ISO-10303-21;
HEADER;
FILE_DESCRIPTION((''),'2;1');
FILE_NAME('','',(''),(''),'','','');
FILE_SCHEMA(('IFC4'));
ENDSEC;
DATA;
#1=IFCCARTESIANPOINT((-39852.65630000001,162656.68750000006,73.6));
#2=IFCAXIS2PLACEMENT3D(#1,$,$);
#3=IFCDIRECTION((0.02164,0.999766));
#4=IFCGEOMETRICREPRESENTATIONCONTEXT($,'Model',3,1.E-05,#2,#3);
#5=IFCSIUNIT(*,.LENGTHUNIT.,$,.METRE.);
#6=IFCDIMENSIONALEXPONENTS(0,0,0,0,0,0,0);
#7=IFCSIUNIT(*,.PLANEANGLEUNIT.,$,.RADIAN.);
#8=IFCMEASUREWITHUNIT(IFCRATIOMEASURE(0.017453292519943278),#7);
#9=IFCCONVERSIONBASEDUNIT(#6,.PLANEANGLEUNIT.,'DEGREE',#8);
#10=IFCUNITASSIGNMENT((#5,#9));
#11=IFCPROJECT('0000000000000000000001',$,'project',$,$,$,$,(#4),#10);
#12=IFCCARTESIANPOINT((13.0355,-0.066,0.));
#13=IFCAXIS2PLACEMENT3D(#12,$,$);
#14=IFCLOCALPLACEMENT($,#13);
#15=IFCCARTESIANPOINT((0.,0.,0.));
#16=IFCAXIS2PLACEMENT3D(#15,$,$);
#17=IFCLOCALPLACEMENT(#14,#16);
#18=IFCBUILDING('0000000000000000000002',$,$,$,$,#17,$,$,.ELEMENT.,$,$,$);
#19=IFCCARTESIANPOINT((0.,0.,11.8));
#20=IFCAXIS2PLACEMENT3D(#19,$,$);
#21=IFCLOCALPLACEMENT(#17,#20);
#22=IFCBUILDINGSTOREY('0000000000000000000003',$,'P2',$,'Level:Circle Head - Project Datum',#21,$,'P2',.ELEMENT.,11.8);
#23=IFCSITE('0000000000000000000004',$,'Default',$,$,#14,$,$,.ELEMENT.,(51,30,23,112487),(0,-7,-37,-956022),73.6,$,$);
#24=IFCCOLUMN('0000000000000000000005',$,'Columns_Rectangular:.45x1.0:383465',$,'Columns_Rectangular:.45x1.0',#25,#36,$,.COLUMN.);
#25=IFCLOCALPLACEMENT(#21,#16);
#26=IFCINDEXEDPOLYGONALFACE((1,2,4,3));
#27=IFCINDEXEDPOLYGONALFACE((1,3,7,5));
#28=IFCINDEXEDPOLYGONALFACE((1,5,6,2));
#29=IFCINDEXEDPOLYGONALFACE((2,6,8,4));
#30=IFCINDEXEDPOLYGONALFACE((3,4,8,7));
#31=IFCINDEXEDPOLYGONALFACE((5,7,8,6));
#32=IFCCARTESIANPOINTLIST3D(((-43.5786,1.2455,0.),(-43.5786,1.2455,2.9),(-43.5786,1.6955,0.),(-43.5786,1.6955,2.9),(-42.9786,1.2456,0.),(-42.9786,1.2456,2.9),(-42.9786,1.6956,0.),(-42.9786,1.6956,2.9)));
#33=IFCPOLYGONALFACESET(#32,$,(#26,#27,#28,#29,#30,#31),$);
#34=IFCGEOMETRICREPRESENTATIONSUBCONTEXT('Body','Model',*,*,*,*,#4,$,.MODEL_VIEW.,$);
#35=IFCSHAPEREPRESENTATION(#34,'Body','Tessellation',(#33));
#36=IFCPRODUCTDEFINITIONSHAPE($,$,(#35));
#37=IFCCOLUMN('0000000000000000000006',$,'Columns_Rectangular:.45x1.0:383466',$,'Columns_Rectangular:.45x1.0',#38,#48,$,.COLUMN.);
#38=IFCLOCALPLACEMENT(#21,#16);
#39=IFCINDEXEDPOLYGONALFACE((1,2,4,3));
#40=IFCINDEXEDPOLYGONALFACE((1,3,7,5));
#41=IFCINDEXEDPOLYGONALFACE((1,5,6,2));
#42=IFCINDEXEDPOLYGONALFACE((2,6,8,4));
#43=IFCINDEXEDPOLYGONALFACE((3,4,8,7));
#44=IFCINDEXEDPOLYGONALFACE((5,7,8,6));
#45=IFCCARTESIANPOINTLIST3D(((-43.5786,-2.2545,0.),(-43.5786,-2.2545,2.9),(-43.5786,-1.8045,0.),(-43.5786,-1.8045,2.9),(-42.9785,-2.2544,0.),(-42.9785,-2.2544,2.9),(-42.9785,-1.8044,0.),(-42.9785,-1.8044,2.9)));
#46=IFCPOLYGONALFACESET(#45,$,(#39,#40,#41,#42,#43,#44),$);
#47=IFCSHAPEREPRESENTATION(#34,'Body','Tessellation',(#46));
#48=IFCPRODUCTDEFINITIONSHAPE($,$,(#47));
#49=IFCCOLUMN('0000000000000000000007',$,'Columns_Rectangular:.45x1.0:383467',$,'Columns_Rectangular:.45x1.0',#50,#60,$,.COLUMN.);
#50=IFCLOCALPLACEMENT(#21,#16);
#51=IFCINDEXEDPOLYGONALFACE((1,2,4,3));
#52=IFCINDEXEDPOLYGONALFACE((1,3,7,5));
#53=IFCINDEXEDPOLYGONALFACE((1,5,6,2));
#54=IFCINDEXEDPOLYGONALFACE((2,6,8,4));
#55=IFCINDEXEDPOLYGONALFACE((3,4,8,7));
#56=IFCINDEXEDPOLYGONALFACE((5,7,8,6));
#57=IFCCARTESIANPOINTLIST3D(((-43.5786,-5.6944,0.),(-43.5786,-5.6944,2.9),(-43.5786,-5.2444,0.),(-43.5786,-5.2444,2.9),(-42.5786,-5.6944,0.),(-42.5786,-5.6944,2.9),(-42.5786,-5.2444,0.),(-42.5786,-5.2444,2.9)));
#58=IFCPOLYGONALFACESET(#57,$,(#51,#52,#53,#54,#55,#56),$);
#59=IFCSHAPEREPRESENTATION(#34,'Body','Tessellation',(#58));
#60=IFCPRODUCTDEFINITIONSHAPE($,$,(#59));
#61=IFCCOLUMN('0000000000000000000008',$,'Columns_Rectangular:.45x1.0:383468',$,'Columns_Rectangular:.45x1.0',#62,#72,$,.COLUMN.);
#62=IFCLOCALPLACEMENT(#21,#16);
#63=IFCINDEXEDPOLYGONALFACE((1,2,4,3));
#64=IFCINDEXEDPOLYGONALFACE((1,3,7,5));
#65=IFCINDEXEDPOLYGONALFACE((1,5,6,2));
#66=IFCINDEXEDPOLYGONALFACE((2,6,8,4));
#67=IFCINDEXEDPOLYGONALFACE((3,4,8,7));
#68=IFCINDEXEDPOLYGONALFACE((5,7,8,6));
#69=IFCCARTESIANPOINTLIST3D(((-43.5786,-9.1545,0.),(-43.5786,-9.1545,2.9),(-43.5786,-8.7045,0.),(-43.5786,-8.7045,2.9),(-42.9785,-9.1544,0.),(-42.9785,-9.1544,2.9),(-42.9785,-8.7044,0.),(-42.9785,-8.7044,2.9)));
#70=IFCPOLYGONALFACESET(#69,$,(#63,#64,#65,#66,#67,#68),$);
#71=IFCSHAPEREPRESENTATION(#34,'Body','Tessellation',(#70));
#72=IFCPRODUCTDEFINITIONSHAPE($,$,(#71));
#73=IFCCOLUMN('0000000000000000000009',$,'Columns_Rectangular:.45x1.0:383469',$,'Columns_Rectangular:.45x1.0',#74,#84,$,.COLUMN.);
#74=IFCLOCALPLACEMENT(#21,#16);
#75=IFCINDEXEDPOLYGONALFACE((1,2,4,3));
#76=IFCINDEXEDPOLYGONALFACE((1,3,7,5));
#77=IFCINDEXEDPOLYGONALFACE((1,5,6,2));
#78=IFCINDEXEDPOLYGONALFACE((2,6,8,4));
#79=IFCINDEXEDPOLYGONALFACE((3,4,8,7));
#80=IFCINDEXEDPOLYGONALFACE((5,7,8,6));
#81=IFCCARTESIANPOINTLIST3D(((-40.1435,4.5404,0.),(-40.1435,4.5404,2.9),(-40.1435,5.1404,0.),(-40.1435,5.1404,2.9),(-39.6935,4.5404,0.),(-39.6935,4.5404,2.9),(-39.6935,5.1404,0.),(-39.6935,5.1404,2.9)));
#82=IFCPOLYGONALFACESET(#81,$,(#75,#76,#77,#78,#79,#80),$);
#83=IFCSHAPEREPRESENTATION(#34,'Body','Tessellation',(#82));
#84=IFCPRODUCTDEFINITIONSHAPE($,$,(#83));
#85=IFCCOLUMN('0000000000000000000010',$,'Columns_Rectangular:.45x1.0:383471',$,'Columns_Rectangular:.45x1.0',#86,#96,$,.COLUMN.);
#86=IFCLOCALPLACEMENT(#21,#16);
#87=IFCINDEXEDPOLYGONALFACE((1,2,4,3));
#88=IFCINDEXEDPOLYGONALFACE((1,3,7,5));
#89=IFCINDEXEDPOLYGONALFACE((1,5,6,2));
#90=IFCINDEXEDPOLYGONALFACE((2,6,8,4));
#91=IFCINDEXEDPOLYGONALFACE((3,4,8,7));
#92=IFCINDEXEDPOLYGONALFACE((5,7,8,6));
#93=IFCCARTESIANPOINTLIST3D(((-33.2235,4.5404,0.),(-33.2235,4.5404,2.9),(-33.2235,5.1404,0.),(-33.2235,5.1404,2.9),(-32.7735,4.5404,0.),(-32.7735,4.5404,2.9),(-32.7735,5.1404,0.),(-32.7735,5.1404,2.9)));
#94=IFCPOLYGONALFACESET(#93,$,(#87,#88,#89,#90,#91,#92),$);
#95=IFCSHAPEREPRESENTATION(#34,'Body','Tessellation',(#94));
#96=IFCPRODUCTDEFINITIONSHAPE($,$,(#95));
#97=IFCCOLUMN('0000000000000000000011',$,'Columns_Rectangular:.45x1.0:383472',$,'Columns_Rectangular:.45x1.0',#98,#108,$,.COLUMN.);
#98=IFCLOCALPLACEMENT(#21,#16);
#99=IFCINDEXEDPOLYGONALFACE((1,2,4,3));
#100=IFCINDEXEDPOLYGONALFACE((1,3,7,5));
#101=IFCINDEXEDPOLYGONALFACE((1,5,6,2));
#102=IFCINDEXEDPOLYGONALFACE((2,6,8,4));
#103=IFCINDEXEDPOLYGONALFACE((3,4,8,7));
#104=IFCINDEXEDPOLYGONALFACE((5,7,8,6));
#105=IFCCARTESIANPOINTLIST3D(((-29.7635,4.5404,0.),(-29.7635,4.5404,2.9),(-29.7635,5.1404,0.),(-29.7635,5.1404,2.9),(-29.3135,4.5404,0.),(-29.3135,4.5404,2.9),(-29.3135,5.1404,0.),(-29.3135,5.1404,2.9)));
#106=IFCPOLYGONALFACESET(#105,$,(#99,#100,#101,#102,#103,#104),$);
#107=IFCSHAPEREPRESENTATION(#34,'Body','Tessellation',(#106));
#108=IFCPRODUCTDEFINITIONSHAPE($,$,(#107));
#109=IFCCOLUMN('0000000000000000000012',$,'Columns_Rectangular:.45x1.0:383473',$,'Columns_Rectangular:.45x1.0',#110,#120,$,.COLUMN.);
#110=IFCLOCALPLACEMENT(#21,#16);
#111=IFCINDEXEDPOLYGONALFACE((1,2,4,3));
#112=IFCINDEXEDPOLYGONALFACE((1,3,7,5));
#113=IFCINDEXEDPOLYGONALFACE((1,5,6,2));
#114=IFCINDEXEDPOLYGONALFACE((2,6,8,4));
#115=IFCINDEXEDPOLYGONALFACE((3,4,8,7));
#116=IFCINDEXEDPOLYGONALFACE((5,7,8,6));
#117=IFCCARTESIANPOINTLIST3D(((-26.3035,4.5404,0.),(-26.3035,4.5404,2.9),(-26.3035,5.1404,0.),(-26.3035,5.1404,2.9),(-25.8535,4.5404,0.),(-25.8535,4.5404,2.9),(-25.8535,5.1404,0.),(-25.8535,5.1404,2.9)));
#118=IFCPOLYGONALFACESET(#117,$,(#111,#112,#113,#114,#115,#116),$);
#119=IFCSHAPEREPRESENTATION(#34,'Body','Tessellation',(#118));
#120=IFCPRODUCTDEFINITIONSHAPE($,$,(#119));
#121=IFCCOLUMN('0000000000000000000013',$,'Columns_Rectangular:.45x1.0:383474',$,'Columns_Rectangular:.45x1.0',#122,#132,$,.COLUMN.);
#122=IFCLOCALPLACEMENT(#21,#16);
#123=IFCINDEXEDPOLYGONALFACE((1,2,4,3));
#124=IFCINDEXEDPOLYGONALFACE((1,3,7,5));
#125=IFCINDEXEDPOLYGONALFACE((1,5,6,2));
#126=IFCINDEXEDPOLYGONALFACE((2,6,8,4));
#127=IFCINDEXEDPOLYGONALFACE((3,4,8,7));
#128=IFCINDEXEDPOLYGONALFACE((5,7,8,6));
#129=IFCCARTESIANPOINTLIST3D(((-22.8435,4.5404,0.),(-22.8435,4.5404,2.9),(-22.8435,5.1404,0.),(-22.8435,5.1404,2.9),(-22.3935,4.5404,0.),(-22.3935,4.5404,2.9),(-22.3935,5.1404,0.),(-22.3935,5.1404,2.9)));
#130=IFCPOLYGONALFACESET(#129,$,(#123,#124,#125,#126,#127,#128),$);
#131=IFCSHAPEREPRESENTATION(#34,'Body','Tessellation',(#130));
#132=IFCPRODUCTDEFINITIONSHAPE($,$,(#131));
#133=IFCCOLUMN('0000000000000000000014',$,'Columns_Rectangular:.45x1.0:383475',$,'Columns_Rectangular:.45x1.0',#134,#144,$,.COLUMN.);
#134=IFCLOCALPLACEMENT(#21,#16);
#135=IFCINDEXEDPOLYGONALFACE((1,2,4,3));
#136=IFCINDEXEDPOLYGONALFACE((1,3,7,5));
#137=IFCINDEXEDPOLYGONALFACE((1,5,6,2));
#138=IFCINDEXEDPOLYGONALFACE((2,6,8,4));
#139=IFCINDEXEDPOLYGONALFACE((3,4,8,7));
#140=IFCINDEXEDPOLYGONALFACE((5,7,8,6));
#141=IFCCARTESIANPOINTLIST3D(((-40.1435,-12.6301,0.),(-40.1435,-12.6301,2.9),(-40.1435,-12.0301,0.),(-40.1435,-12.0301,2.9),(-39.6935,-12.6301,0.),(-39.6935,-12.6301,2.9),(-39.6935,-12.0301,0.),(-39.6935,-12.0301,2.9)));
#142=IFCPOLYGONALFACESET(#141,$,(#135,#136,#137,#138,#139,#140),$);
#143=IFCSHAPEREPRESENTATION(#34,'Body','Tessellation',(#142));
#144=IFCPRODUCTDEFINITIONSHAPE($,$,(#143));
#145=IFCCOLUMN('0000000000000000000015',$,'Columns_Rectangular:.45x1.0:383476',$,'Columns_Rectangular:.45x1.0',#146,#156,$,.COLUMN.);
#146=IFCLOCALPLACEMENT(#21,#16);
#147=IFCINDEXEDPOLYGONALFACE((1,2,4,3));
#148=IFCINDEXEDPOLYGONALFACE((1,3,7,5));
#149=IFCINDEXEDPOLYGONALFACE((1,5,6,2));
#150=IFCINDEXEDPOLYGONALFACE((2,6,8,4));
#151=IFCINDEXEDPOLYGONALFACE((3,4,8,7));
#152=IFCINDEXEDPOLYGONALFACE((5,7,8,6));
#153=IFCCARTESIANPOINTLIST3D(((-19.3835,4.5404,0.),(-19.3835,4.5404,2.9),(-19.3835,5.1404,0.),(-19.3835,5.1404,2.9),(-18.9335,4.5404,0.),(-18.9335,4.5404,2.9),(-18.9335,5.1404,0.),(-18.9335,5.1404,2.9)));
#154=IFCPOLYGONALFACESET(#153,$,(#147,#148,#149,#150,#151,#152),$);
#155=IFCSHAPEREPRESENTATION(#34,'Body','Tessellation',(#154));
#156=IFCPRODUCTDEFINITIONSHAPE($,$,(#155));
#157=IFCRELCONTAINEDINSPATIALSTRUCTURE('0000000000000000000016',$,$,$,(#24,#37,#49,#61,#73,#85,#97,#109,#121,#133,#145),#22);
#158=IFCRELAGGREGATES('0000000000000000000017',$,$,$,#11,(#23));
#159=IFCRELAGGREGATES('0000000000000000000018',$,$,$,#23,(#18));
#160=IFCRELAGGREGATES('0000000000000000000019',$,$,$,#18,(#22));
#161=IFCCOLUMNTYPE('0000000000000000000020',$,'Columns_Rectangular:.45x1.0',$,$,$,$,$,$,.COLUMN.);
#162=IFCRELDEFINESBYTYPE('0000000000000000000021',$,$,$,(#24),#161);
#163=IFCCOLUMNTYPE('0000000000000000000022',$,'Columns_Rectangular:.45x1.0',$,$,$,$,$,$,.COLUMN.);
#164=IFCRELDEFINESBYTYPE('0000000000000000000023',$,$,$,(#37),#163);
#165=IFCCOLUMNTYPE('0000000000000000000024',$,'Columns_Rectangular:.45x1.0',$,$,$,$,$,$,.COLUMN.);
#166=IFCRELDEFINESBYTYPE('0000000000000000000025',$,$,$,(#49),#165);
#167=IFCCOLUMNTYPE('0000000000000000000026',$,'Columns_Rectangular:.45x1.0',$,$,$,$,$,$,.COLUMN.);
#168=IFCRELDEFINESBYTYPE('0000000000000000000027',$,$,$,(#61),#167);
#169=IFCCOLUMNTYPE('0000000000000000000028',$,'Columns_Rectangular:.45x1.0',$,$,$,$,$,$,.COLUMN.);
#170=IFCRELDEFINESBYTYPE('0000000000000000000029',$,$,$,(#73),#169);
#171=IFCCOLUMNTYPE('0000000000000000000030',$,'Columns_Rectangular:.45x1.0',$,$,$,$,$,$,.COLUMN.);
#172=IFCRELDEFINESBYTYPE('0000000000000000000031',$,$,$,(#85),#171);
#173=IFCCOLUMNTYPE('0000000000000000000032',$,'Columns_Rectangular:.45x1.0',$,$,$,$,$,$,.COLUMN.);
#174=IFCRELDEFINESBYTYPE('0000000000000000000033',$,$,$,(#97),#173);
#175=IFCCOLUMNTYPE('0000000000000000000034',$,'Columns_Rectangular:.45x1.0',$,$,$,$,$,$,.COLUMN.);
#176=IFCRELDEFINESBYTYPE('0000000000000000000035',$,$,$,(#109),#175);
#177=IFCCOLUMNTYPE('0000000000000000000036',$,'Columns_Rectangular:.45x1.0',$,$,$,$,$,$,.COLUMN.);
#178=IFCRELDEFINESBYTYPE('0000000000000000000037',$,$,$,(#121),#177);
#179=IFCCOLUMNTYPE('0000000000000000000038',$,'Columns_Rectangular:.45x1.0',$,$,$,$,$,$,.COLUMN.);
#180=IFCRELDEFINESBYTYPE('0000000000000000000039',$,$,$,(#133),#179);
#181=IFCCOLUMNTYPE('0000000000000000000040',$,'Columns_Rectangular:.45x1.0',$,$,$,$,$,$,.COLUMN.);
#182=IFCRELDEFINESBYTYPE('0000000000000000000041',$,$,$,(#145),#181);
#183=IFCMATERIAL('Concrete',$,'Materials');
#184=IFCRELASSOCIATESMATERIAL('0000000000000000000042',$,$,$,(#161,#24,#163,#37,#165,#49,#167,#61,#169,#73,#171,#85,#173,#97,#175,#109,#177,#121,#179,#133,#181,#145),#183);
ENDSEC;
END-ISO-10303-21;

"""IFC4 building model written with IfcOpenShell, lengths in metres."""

from ifc_helpers import new_model, entity, si_unit, converted_unit, direction, frame, origin, place, context, subcontext, project, spatial, indexed_curve, outline, extrude, source, transform, mapped, material, type_object, type_shapes, element, save


model = new_model("IFC4")

# Units and contexts
model_context = context("Model", 3, precision=1e-05, world=frame((-39852.65630000001, 162656.68750000006, 73.6)), true_north=direction((0.02164, 0.999766)))
body_context = subcontext(model_context, "Body", "Model", "MODEL_VIEW")
ifc_project = project(units=[si_unit("LENGTHUNIT", "METRE"), converted_unit("PLANEANGLEUNIT", "DEGREE", entity("IfcRatioMeasure", 0.017453292519943278), si_unit("PLANEANGLEUNIT", "RADIAN"), dimensions=[0, 0, 0, 0, 0, 0, 0])], contexts=[model_context])

# Site, building, storey
site_placement = place(None, frame((13.0355, -0.066, 0.0)))
site = spatial("IfcSite", under=ifc_project, at=site_placement, Name="Default", CompositionType="ELEMENT", RefLatitude=(51, 30, 23, 112487), RefLongitude=(0, -7, -37, -956022), RefElevation=73.6)
building_placement = place(site_placement, origin())
building = spatial("IfcBuilding", under=site, at=building_placement, CompositionType="ELEMENT")
storey_placement = place(building_placement, frame((0.0, 0.0, 11.8)))
storey = spatial("IfcBuildingStorey", under=building, at=storey_placement, Name="P2", ObjectType="Level:Circle Head - Project Datum", LongName="P2", CompositionType="ELEMENT", Elevation=11.8)

# Columns
ifc_material = material(Name="Concrete", Category="Materials")
column_type_1 = type_object("IfcColumnType", Name="Columns_Rectangular:.45x1.0", PredefinedType="COLUMN", material=ifc_material)
shared_shape_1 = source(origin(), body_context, "Body", "SweptSolid", [
    extrude(outline(indexed_curve([(-0.3, -0.225), (0.3, -0.225), (0.3, 0.225), (-0.3, 0.225), (-0.3, -0.225)], self_intersect=False)), frame((-43.2786, 1.4706, 11.8), z_axis=(0.0, 0.0, 1.0), x_axis=(-1.0, -0.000005, 0.0)), (0.0, 0.0, 1.0), 2.9),
])
type_shapes(column_type_1, [shared_shape_1])
column_1_placement = place(storey_placement, frame((0.0, 0.0, -11.8)))
element("IfcColumn", 1, at=column_1_placement, inside=storey, type_object=column_type_1, material=ifc_material, Name="Columns_Rectangular:.45x1.0:383465", ObjectType="Columns_Rectangular:.45x1.0", PredefinedType="COLUMN", context=body_context, shape_type="MappedRepresentation", body=[
    mapped(shared_shape_1, transform((0.0, 0.0, 0.0), scale=1.0)),
])
column_type_2 = type_object("IfcColumnType", Name="Columns_Rectangular:.45x1.0", PredefinedType="COLUMN", material=ifc_material)
shared_shape_2 = source(origin(), body_context, "Body", "SweptSolid", [
    extrude(outline(indexed_curve([(-0.3, -0.225), (0.3, -0.225), (0.3, 0.225), (-0.3, 0.225), (-0.3, -0.225)], self_intersect=False)), frame((-43.2785, -2.0294, 11.8), z_axis=(0.0, 0.0, 1.0), x_axis=(-1.0, -0.000005, 0.0)), (0.0, 0.0, 1.0), 2.9),
])
type_shapes(column_type_2, [shared_shape_2])
column_2_placement = place(storey_placement, frame((0.0, 0.0, -11.8)))
element("IfcColumn", 2, at=column_2_placement, inside=storey, type_object=column_type_2, material=ifc_material, Name="Columns_Rectangular:.45x1.0:383466", ObjectType="Columns_Rectangular:.45x1.0", PredefinedType="COLUMN", context=body_context, shape_type="MappedRepresentation", body=[
    mapped(shared_shape_2, transform((0.0, 0.0, 0.0), scale=1.0)),
])
column_type_3 = type_object("IfcColumnType", Name="Columns_Rectangular:.45x1.0", PredefinedType="COLUMN", material=ifc_material)
shared_shape_3 = source(origin(), body_context, "Body", "SweptSolid", [
    extrude(outline(indexed_curve([(-0.225, -0.5), (0.225, -0.5), (0.225, 0.5), (-0.225, 0.5), (-0.225, -0.5)], self_intersect=False)), frame((-43.0786, -5.4694, 11.8), z_axis=(0.0, 0.0, 1.0), x_axis=(0.0, -1.0, 0.0)), (0.0, 0.0, 1.0), 2.9),
])
type_shapes(column_type_3, [shared_shape_3])
column_3_placement = place(storey_placement, frame((0.0, 0.0, -11.8)))
element("IfcColumn", 3, at=column_3_placement, inside=storey, type_object=column_type_3, material=ifc_material, Name="Columns_Rectangular:.45x1.0:383467", ObjectType="Columns_Rectangular:.45x1.0", PredefinedType="COLUMN", context=body_context, shape_type="MappedRepresentation", body=[
    mapped(shared_shape_3, transform((0.0, 0.0, 0.0), scale=1.0)),
])
column_type_4 = type_object("IfcColumnType", Name="Columns_Rectangular:.45x1.0", PredefinedType="COLUMN", material=ifc_material)
shared_shape_4 = source(origin(), body_context, "Body", "SweptSolid", [
    extrude(outline(indexed_curve([(-0.3, -0.225), (0.3, -0.225), (0.3, 0.225), (-0.3, 0.225), (-0.3, -0.225)], self_intersect=False)), frame((-43.2785, -8.9294, 11.8), z_axis=(0.0, 0.0, 1.0), x_axis=(-1.0, -0.000005, 0.0)), (0.0, 0.0, 1.0), 2.9),
])
type_shapes(column_type_4, [shared_shape_4])
column_4_placement = place(storey_placement, frame((0.0, 0.0, -11.8)))
element("IfcColumn", 4, at=column_4_placement, inside=storey, type_object=column_type_4, material=ifc_material, Name="Columns_Rectangular:.45x1.0:383468", ObjectType="Columns_Rectangular:.45x1.0", PredefinedType="COLUMN", context=body_context, shape_type="MappedRepresentation", body=[
    mapped(shared_shape_4, transform((0.0, 0.0, 0.0), scale=1.0)),
])
column_type_5 = type_object("IfcColumnType", Name="Columns_Rectangular:.45x1.0", PredefinedType="COLUMN", material=ifc_material)
shared_shape_5 = source(origin(), body_context, "Body", "SweptSolid", [
    extrude(outline(indexed_curve([(-0.3, -0.225), (0.3, -0.225), (0.3, 0.225), (-0.3, 0.225), (-0.3, -0.225)], self_intersect=False)), frame((-39.9185, 4.8404, 11.8), z_axis=(0.0, 0.0, 1.0), x_axis=(0.0, -1.0, 0.0)), (0.0, 0.0, 1.0), 2.9),
])
type_shapes(column_type_5, [shared_shape_5])
column_5_placement = place(storey_placement, frame((0.0, 0.0, -11.8)))
element("IfcColumn", 5, at=column_5_placement, inside=storey, type_object=column_type_5, material=ifc_material, Name="Columns_Rectangular:.45x1.0:383469", ObjectType="Columns_Rectangular:.45x1.0", PredefinedType="COLUMN", context=body_context, shape_type="MappedRepresentation", body=[
    mapped(shared_shape_5, transform((0.0, 0.0, 0.0), scale=1.0)),
])
column_type_6 = type_object("IfcColumnType", Name="Columns_Rectangular:.45x1.0", PredefinedType="COLUMN", material=ifc_material)
shared_shape_6 = source(origin(), body_context, "Body", "SweptSolid", [
    extrude(outline(indexed_curve([(-0.3, -0.225), (0.3, -0.225), (0.3, 0.225), (-0.3, 0.225), (-0.3, -0.225)], self_intersect=False)), frame((-32.9985, 4.8404, 11.8), z_axis=(0.0, 0.0, 1.0), x_axis=(0.0, -1.0, 0.0)), (0.0, 0.0, 1.0), 2.9),
])
type_shapes(column_type_6, [shared_shape_6])
column_6_placement = place(storey_placement, frame((0.0, 0.0, -11.8)))
element("IfcColumn", 6, at=column_6_placement, inside=storey, type_object=column_type_6, material=ifc_material, Name="Columns_Rectangular:.45x1.0:383471", ObjectType="Columns_Rectangular:.45x1.0", PredefinedType="COLUMN", context=body_context, shape_type="MappedRepresentation", body=[
    mapped(shared_shape_6, transform((0.0, 0.0, 0.0), scale=1.0)),
])
column_type_7 = type_object("IfcColumnType", Name="Columns_Rectangular:.45x1.0", PredefinedType="COLUMN", material=ifc_material)
shared_shape_7 = source(origin(), body_context, "Body", "SweptSolid", [
    extrude(outline(indexed_curve([(-0.3, -0.225), (0.3, -0.225), (0.3, 0.225), (-0.3, 0.225), (-0.3, -0.225)], self_intersect=False)), frame((-29.5385, 4.8404, 11.8), z_axis=(0.0, 0.0, 1.0), x_axis=(0.0, -1.0, 0.0)), (0.0, 0.0, 1.0), 2.9),
])
type_shapes(column_type_7, [shared_shape_7])
column_7_placement = place(storey_placement, frame((0.0, 0.0, -11.8)))
element("IfcColumn", 7, at=column_7_placement, inside=storey, type_object=column_type_7, material=ifc_material, Name="Columns_Rectangular:.45x1.0:383472", ObjectType="Columns_Rectangular:.45x1.0", PredefinedType="COLUMN", context=body_context, shape_type="MappedRepresentation", body=[
    mapped(shared_shape_7, transform((0.0, 0.0, 0.0), scale=1.0)),
])
column_type_8 = type_object("IfcColumnType", Name="Columns_Rectangular:.45x1.0", PredefinedType="COLUMN", material=ifc_material)
shared_shape_8 = source(origin(), body_context, "Body", "SweptSolid", [
    extrude(outline(indexed_curve([(-0.3, -0.225), (0.3, -0.225), (0.3, 0.225), (-0.3, 0.225), (-0.3, -0.225)], self_intersect=False)), frame((-26.0785, 4.8404, 11.8), z_axis=(0.0, 0.0, 1.0), x_axis=(0.0, -1.0, 0.0)), (0.0, 0.0, 1.0), 2.9),
])
type_shapes(column_type_8, [shared_shape_8])
column_8_placement = place(storey_placement, frame((0.0, 0.0, -11.8)))
element("IfcColumn", 8, at=column_8_placement, inside=storey, type_object=column_type_8, material=ifc_material, Name="Columns_Rectangular:.45x1.0:383473", ObjectType="Columns_Rectangular:.45x1.0", PredefinedType="COLUMN", context=body_context, shape_type="MappedRepresentation", body=[
    mapped(shared_shape_8, transform((0.0, 0.0, 0.0), scale=1.0)),
])
column_type_9 = type_object("IfcColumnType", Name="Columns_Rectangular:.45x1.0", PredefinedType="COLUMN", material=ifc_material)
shared_shape_9 = source(origin(), body_context, "Body", "SweptSolid", [
    extrude(outline(indexed_curve([(-0.3, -0.225), (0.3, -0.225), (0.3, 0.225), (-0.3, 0.225), (-0.3, -0.225)], self_intersect=False)), frame((-22.6185, 4.8404, 11.8), z_axis=(0.0, 0.0, 1.0), x_axis=(0.0, -1.0, 0.0)), (0.0, 0.0, 1.0), 2.9),
])
type_shapes(column_type_9, [shared_shape_9])
column_9_placement = place(storey_placement, frame((0.0, 0.0, -11.8)))
element("IfcColumn", 9, at=column_9_placement, inside=storey, type_object=column_type_9, material=ifc_material, Name="Columns_Rectangular:.45x1.0:383474", ObjectType="Columns_Rectangular:.45x1.0", PredefinedType="COLUMN", context=body_context, shape_type="MappedRepresentation", body=[
    mapped(shared_shape_9, transform((0.0, 0.0, 0.0), scale=1.0)),
])
column_type_10 = type_object("IfcColumnType", Name="Columns_Rectangular:.45x1.0", PredefinedType="COLUMN", material=ifc_material)
shared_shape_10 = source(origin(), body_context, "Body", "SweptSolid", [
    extrude(outline(indexed_curve([(-0.3, -0.225), (0.3, -0.225), (0.3, 0.225), (-0.3, 0.225), (-0.3, -0.225)], self_intersect=False)), frame((-39.9185, -12.3301, 11.8), z_axis=(0.0, 0.0, 1.0), x_axis=(0.000011, 1.0, 0.0)), (0.0, 0.0, 1.0), 2.9),
])
type_shapes(column_type_10, [shared_shape_10])
column_10_placement = place(storey_placement, frame((0.0, 0.0, -11.8)))
element("IfcColumn", 10, at=column_10_placement, inside=storey, type_object=column_type_10, material=ifc_material, Name="Columns_Rectangular:.45x1.0:383475", ObjectType="Columns_Rectangular:.45x1.0", PredefinedType="COLUMN", context=body_context, shape_type="MappedRepresentation", body=[
    mapped(shared_shape_10, transform((0.0, 0.0, 0.0), scale=1.0)),
])
column_type_11 = type_object("IfcColumnType", Name="Columns_Rectangular:.45x1.0", PredefinedType="COLUMN", material=ifc_material)
shared_shape_11 = source(origin(), body_context, "Body", "SweptSolid", [
    extrude(outline(indexed_curve([(-0.3, -0.225), (0.3, -0.225), (0.3, 0.225), (-0.3, 0.225), (-0.3, -0.225)], self_intersect=False)), frame((-19.1585, 4.8404, 11.8), z_axis=(0.0, 0.0, 1.0), x_axis=(0.0, -1.0, 0.0)), (0.0, 0.0, 1.0), 2.9),
])
type_shapes(column_type_11, [shared_shape_11])
column_11_placement = place(storey_placement, frame((0.0, 0.0, -11.8)))
element("IfcColumn", 11, at=column_11_placement, inside=storey, type_object=column_type_11, material=ifc_material, Name="Columns_Rectangular:.45x1.0:383476", ObjectType="Columns_Rectangular:.45x1.0", PredefinedType="COLUMN", context=body_context, shape_type="MappedRepresentation", body=[
    mapped(shared_shape_11, transform((0.0, 0.0, 0.0), scale=1.0)),
])

save(model, "model.ifc")
